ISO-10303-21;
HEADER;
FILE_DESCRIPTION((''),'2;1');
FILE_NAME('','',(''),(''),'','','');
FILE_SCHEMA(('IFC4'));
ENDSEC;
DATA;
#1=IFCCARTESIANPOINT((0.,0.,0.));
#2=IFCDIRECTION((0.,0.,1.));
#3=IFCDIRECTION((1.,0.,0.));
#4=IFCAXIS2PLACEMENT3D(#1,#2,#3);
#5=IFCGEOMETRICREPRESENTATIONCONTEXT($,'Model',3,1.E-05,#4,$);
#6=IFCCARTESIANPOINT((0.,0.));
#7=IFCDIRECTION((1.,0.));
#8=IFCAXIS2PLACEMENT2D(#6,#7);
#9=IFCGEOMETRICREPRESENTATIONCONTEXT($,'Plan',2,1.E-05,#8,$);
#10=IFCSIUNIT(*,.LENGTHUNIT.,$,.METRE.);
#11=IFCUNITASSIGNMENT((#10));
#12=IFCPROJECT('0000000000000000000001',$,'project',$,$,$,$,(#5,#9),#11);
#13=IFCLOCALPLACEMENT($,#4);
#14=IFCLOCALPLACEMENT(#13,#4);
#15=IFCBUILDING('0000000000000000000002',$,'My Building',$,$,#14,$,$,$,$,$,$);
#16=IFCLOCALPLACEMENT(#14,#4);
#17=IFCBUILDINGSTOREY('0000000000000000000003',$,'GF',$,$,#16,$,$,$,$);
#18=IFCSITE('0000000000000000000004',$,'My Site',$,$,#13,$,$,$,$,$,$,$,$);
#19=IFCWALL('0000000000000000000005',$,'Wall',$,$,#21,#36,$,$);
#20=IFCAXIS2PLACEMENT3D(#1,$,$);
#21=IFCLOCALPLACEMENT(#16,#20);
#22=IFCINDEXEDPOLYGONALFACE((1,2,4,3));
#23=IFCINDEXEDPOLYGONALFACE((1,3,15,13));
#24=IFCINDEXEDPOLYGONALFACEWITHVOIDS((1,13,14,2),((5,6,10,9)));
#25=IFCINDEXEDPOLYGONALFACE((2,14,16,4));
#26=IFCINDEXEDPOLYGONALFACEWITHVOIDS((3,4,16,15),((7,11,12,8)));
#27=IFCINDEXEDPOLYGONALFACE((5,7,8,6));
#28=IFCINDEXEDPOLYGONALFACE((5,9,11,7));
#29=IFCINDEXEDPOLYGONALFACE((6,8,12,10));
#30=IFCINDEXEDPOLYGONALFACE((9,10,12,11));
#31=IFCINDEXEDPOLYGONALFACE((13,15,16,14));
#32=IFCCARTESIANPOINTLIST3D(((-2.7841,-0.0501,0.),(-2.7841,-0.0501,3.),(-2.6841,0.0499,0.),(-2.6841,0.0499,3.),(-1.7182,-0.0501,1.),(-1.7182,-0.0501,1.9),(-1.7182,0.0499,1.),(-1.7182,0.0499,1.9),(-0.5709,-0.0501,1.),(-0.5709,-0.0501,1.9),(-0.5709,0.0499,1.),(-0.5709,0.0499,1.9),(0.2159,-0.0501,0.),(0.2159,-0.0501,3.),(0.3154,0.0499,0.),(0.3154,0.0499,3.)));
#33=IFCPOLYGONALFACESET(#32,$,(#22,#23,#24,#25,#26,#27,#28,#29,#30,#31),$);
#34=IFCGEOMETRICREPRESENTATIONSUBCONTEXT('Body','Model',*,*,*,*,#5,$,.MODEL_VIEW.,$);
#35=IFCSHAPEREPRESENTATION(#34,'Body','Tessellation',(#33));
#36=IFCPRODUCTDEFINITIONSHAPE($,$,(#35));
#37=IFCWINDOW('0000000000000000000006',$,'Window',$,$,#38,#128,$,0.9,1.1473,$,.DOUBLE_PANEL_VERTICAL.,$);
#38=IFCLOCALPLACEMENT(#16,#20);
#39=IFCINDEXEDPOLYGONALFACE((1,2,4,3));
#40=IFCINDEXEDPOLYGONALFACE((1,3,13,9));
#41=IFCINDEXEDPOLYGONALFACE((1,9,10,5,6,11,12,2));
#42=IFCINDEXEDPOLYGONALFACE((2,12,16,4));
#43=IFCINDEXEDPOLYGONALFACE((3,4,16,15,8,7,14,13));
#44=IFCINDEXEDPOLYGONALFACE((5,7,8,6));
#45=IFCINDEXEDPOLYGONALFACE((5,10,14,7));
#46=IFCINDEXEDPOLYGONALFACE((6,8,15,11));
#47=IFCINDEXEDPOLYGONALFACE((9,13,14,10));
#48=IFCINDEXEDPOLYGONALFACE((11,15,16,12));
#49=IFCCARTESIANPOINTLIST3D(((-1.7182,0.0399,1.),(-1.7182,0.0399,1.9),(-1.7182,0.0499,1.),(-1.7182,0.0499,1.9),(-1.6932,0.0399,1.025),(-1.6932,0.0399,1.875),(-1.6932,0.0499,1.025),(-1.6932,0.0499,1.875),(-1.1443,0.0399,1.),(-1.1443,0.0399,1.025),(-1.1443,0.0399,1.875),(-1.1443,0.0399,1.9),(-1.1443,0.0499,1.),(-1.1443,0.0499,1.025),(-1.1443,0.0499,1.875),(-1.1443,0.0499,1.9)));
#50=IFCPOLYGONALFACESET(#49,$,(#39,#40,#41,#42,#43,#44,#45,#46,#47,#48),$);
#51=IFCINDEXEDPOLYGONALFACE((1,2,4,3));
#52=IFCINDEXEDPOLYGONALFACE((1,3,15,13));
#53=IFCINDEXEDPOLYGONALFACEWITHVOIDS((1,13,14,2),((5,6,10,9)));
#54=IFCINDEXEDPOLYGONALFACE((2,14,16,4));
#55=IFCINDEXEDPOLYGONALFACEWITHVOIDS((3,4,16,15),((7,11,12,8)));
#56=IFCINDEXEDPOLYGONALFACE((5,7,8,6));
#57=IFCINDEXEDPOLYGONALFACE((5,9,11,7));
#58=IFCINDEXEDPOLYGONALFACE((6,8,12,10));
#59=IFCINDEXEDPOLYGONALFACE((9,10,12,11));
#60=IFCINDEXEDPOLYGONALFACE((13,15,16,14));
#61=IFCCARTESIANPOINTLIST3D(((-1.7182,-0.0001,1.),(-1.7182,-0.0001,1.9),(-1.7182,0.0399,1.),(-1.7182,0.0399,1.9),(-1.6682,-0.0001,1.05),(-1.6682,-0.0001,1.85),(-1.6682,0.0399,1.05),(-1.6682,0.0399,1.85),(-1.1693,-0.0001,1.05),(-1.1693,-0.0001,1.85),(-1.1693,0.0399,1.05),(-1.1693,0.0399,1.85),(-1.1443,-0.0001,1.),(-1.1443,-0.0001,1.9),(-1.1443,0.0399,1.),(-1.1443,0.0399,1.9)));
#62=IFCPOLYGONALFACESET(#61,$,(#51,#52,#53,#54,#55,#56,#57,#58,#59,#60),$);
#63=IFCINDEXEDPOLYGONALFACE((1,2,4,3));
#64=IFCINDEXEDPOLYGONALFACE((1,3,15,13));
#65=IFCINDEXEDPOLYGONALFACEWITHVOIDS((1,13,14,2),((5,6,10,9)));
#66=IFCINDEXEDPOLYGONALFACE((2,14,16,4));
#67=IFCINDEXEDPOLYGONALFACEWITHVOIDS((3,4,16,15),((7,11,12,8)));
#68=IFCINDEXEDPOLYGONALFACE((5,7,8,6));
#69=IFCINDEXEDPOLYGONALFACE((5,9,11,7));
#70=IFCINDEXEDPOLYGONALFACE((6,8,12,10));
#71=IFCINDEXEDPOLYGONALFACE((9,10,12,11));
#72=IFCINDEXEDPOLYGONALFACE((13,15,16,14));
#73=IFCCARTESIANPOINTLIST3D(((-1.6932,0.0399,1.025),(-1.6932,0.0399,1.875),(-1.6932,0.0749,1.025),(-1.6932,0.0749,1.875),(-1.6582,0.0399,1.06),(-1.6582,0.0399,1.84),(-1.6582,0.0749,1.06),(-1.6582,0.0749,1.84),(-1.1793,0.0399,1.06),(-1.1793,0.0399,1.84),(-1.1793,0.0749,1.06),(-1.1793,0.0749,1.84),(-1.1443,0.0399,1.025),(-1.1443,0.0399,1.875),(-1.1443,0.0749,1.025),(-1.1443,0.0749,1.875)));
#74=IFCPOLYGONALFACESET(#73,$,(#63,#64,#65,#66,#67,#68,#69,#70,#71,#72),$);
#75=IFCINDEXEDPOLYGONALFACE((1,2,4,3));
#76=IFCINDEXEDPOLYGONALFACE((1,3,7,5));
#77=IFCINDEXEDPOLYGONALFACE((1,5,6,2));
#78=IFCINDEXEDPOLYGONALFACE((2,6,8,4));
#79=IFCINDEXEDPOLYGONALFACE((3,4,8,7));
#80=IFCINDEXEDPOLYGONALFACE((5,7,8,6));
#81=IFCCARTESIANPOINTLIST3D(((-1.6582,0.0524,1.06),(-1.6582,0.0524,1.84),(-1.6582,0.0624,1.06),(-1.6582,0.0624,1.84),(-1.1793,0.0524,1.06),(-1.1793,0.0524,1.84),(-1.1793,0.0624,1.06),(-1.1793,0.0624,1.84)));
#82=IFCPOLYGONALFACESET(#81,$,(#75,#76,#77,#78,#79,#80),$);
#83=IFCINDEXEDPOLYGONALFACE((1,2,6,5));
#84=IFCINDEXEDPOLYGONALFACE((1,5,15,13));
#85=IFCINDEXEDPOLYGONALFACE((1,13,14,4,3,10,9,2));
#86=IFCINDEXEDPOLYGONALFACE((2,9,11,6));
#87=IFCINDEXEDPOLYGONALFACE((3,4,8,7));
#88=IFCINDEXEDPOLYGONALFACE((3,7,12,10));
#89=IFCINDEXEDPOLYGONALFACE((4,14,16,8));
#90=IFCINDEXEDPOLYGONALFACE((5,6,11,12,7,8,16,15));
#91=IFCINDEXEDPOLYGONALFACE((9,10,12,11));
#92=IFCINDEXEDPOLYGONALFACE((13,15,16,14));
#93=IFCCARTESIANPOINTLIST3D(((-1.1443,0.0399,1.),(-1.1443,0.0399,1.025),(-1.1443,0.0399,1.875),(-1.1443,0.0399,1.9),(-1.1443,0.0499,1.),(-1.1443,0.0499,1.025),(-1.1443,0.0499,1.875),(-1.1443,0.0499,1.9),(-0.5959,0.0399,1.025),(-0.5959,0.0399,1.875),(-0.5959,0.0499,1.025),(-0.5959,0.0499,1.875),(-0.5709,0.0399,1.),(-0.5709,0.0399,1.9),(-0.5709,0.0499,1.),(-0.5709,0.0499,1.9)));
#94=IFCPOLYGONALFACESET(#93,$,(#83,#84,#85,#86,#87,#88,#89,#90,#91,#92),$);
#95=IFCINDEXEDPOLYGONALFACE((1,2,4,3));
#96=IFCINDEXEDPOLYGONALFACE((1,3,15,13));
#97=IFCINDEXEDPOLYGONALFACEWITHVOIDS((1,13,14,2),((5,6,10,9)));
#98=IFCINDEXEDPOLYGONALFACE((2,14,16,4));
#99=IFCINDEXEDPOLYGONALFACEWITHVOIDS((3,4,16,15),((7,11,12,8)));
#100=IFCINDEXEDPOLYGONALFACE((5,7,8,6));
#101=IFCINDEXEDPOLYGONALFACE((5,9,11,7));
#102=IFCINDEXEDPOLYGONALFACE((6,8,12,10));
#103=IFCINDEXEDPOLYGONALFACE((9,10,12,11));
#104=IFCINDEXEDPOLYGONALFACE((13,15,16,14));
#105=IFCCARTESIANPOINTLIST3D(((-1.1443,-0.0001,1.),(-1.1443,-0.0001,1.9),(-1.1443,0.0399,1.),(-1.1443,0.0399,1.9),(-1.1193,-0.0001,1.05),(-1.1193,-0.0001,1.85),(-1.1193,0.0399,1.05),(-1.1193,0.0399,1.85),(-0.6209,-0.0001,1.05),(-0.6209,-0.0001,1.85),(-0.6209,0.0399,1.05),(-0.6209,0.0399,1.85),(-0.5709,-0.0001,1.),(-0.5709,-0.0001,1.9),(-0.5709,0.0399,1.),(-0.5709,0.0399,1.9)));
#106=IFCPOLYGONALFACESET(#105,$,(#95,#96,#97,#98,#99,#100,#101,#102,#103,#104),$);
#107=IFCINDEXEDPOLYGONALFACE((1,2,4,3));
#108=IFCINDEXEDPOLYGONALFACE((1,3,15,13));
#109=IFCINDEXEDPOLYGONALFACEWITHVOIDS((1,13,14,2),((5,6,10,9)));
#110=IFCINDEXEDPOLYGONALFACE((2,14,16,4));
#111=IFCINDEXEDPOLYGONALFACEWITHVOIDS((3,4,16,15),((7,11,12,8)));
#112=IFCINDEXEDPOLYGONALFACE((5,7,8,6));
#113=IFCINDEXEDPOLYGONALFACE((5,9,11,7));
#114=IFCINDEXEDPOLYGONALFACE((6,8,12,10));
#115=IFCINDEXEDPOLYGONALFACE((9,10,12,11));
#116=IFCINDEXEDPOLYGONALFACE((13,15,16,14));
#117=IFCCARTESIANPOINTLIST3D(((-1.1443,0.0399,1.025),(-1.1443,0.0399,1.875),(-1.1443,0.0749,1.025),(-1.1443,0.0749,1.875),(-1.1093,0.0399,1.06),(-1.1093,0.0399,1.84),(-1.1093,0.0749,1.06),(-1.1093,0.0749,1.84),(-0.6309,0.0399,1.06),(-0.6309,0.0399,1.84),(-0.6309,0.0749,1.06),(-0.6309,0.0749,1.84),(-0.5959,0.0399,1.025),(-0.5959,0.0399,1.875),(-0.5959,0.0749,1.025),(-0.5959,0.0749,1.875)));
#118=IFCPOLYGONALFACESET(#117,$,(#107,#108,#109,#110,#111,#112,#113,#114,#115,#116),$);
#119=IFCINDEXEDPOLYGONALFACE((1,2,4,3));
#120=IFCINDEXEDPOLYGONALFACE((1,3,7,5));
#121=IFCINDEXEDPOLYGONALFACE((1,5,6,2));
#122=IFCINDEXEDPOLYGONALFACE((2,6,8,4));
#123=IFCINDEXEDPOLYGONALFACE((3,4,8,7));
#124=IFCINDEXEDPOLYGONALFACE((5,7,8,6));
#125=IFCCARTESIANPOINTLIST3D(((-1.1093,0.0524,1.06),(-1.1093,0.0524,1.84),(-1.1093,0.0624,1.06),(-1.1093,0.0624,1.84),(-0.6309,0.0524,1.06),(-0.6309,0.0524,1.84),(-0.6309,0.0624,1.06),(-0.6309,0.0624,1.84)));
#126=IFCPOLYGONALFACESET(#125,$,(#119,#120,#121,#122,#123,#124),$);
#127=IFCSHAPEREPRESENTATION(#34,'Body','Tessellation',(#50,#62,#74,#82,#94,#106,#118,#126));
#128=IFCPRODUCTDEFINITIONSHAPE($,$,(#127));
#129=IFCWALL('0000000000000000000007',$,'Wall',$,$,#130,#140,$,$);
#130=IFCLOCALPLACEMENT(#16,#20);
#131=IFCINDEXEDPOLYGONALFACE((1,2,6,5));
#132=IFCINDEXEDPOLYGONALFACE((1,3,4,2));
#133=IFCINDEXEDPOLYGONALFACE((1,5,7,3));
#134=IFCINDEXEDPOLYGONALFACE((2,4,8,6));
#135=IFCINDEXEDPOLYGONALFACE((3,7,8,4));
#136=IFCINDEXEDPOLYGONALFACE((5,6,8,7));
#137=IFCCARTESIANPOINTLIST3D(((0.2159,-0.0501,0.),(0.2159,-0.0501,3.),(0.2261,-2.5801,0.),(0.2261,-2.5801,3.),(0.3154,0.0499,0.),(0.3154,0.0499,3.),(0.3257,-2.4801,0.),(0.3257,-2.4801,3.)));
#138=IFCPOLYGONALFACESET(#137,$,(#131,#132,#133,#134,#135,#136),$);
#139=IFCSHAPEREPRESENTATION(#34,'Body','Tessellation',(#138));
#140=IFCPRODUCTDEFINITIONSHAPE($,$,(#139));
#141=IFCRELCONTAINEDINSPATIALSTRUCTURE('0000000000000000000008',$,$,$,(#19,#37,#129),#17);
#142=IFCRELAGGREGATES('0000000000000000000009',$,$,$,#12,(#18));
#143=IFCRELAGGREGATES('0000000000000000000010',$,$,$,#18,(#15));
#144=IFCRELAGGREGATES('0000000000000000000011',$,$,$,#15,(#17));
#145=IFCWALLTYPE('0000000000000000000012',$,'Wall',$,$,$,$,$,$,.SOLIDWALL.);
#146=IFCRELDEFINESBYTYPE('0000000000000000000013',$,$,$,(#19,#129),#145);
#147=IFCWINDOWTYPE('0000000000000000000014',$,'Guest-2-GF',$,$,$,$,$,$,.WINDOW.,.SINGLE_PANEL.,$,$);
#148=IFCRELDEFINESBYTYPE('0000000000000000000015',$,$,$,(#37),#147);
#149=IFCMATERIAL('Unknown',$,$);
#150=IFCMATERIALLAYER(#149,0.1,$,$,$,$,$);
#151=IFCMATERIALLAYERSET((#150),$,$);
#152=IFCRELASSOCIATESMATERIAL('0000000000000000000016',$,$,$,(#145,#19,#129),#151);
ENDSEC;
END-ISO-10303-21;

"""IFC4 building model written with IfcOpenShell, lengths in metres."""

from ifc_helpers import new_model, entity, si_unit, frame, origin_with_axes, origin_2d_with_axis, place, context, subcontext, project, spatial, line, indexed_curve, outline, extrude, shape, source, transform, mapped, material, layer, layer_set, layer_usage, type_object, type_shapes, element, fill, save


model = new_model("IFC4")

# Units and contexts
model_context = context("Model", 3, precision=1e-05, world=origin_with_axes())
plan_context = context("Plan", 2, precision=1e-05, world=origin_2d_with_axis())
body_context_1 = subcontext(model_context, "Body", "Model", "MODEL_VIEW")
body_context_2 = subcontext(plan_context, "Body", "Plan", "PLAN_VIEW")
ifc_project = project(units=[si_unit("LENGTHUNIT", "METRE")], contexts=[model_context, plan_context])

# Site, building, storey
site_placement = place(None, origin_with_axes())
site = spatial("IfcSite", under=ifc_project, at=site_placement, Name="My Site")
building_placement = place(site_placement, origin_with_axes())
building = spatial("IfcBuilding", under=site, at=building_placement, Name="My Building")
storey_placement = place(building_placement, origin_with_axes())
storey = spatial("IfcBuildingStorey", under=building, at=storey_placement, Name="GF")

# Shared definitions
ifc_material_1 = material(Name="Unknown")

# Shared definitions
ifc_layer_1 = layer(ifc_material_1, 0.1)
ifc_layer_set_1 = layer_set([ifc_layer_1])
wall_type = type_object("IfcWallType", Name="Wall", PredefinedType="SOLIDWALL", material=ifc_layer_set_1)

# Wall, opening, window
ifc_layer_usage_1 = layer_usage(ifc_layer_set_1, "AXIS2", "POSITIVE", 0.0)
wall_1_placement = place(storey_placement, frame((-2.7841, -0.0501, 0.0), z_axis=(0.0, 0.0, 1.0), x_axis=(1.0, 0.0, 0.0)))
wall_1 = element("IfcWall", 1, at=wall_1_placement, inside=storey, type_object=wall_type, material=ifc_layer_usage_1, Name="Wall", context=body_context_1, shape_type="SweptSolid", body=[
    extrude(outline(indexed_curve([(0.0, 0.0), (0.1, 0.1), (3.0996, 0.1), (3.0, 0.0)], segments=[line(1, 2, 3, 4, 1)])), origin_with_axes(), (0.0, 0.0, 1.0), 3.0),
])
shared_shape_1 = source(origin_with_axes(), body_context_1, "Body", "SweptSolid", [
    extrude(outline(indexed_curve([(0.0, 0.0), (1.1473, 0.0), (1.1473, 0.9), (0.0, 0.9)], segments=[line(1, 2, 3, 4, 1)])), frame((0.0, -0.6, 0.0), z_axis=(0.0, -1.0, 0.0), x_axis=(1.0, 0.0, 0.0)), (0.0, 0.0, -1.0), 1.2),
])
opening_1_placement = place(wall_1_placement, frame((1.066, 0.0, 1.0), z_axis=(0.0, 0.0, 1.0), x_axis=(1.0, 0.0, 0.0)))
opening_1 = element("IfcOpeningElement", 2, at=opening_1_placement, cuts=wall_1, PredefinedType="OPENING", context=body_context_1, shape_type="MappedRepresentation", body=[
    mapped(shared_shape_1, transform((0.0, 0.0, 0.0), x_axis=(1.0, 0.0, 0.0), y_axis=(0.0, 1.0, 0.0), z_axis=(0.0, 0.0, 1.0), scale=1.0)),
])
window_type_1 = type_object("IfcWindowType", Name="Guest-2-GF", PartitioningType="SINGLE_PANEL", PredefinedType="WINDOW")
shared_shape_2 = source(origin_with_axes(), body_context_1, "Body", "SweptSolid", [
    extrude(outline(indexed_curve([(0.5739, 0.0), (0.0, 0.0), (0.0, 0.9), (0.5739, 0.9), (0.5739, 0.875), (0.025, 0.875), (0.025, 0.025), (0.5739, 0.025)], segments=[line(1, 2, 3, 4, 5, 6, 7, 8, 1)])), frame((0.0, 0.09, 0.0), z_axis=(0.0, -1.0, 0.0), x_axis=(1.0, 0.0, 0.0)), (0.0, 0.0, -1.0), 0.01),
    extrude(outline(indexed_curve([(0.0, 0.0), (0.5739, 0.0), (0.5739, 0.9), (0.0, 0.9)], segments=[line(1, 2, 3, 4, 1)]), holes=[indexed_curve([(0.05, 0.05), (0.5489, 0.05), (0.5489, 0.85), (0.05, 0.85)], segments=[line(1, 2, 3, 4, 1)])]), frame((0.0, 0.05, 0.0), z_axis=(0.0, -1.0, 0.0), x_axis=(1.0, 0.0, 0.0)), (0.0, 0.0, -1.0), 0.04),
    extrude(outline(indexed_curve([(0.0, 0.0), (0.5489, 0.0), (0.5489, 0.85), (0.0, 0.85)], segments=[line(1, 2, 3, 4, 1)]), holes=[indexed_curve([(0.035, 0.035), (0.5139, 0.035), (0.5139, 0.815), (0.035, 0.815)], segments=[line(1, 2, 3, 4, 1)])]), frame((0.025, 0.09, 0.025), z_axis=(0.0, -1.0, 0.0), x_axis=(1.0, 0.0, 0.0)), (0.0, 0.0, -1.0), 0.035),
    extrude(outline(indexed_curve([(0.035, 0.035), (0.5139, 0.035), (0.5139, 0.815), (0.035, 0.815)], segments=[line(1, 2, 3, 4, 1)])), frame((0.025, 0.1025, 0.025), z_axis=(0.0, -1.0, 0.0), x_axis=(1.0, 0.0, 0.0)), (0.0, 0.0, -1.0), 0.01),
    extrude(outline(indexed_curve([(0.0, 0.9), (0.5733, 0.9), (0.5733, 0.0), (0.0, 0.0), (0.0, 0.025), (0.5483, 0.025), (0.5483, 0.875), (0.0, 0.875)], segments=[line(1, 2, 3, 4, 5, 6, 7, 8, 1)])), frame((0.5739, 0.09, 0.0), z_axis=(0.0, -1.0, 0.0), x_axis=(1.0, 0.0, 0.0)), (0.0, 0.0, -1.0), 0.01),
    extrude(outline(indexed_curve([(0.0, 0.0), (0.5733, 0.0), (0.5733, 0.9), (0.0, 0.9)], segments=[line(1, 2, 3, 4, 1)]), holes=[indexed_curve([(0.025, 0.05), (0.5233, 0.05), (0.5233, 0.85), (0.025, 0.85)], segments=[line(1, 2, 3, 4, 1)])]), frame((0.5739, 0.05, 0.0), z_axis=(0.0, -1.0, 0.0), x_axis=(1.0, 0.0, 0.0)), (0.0, 0.0, -1.0), 0.04),
    extrude(outline(indexed_curve([(0.0, 0.0), (0.5483, 0.0), (0.5483, 0.85), (0.0, 0.85)], segments=[line(1, 2, 3, 4, 1)]), holes=[indexed_curve([(0.035, 0.035), (0.5133, 0.035), (0.5133, 0.815), (0.035, 0.815)], segments=[line(1, 2, 3, 4, 1)])]), frame((0.5739, 0.09, 0.025), z_axis=(0.0, -1.0, 0.0), x_axis=(1.0, 0.0, 0.0)), (0.0, 0.0, -1.0), 0.035),
    extrude(outline(indexed_curve([(0.035, 0.035), (0.5133, 0.035), (0.5133, 0.815), (0.035, 0.815)], segments=[line(1, 2, 3, 4, 1)])), frame((0.5739, 0.1025, 0.025), z_axis=(0.0, -1.0, 0.0), x_axis=(1.0, 0.0, 0.0)), (0.0, 0.0, -1.0), 0.01),
])
shared_shape_3 = source(origin_with_axes(), body_context_2, "Body", "Curve2D", [
    entity("IfcIndexedPolyCurve", entity("IfcCartesianPointList2D", [[0.05, 0.05], [0.5489, 0.05]])),
    entity("IfcIndexedPolyCurve", entity("IfcCartesianPointList2D", [[0.0, 0.1], [0.025, 0.1], [0.025, 0.09], [0.05, 0.09], [0.05, 0.05], [0.0, 0.05]]), [entity("IfcLineIndex", [1, 2, 3, 4, 5, 6, 1])]),
    entity("IfcIndexedPolyCurve", entity("IfcCartesianPointList2D", [[0.5739, 0.1], [0.5739, 0.1], [0.5739, 0.09], [0.5489, 0.09], [0.5489, 0.05], [0.5739, 0.05]])),
    entity("IfcIndexedPolyCurve", entity("IfcCartesianPointList2D", [[0.025, 0.09], [0.06, 0.09], [0.06, 0.125], [0.025, 0.125]]), [entity("IfcLineIndex", [1, 2, 3, 4, 1])]),
    entity("IfcIndexedPolyCurve", entity("IfcCartesianPointList2D", [[0.5739, 0.09], [0.5389, 0.09], [0.5389, 0.125], [0.5739, 0.125]]), [entity("IfcLineIndex", [1, 2, 3, 4, 1])]),
    entity("IfcIndexedPolyCurve", entity("IfcCartesianPointList2D", [[0.06, 0.09], [0.5389, 0.09]])),
    entity("IfcIndexedPolyCurve", entity("IfcCartesianPointList2D", [[0.06, 0.125], [0.5389, 0.125]])),
    entity("IfcIndexedPolyCurve", entity("IfcCartesianPointList2D", [[0.06, 0.1075], [0.5389, 0.1075]])),
    entity("IfcIndexedPolyCurve", entity("IfcCartesianPointList2D", [[0.5989, 0.05], [1.0973, 0.05]])),
    entity("IfcIndexedPolyCurve", entity("IfcCartesianPointList2D", [[0.5739, 0.1], [0.5739, 0.1], [0.5739, 0.09], [0.5989, 0.09], [0.5989, 0.05], [0.5739, 0.05]])),
    entity("IfcIndexedPolyCurve", entity("IfcCartesianPointList2D", [[1.1473, 0.1], [1.1223, 0.1], [1.1223, 0.09], [1.0973, 0.09], [1.0973, 0.05], [1.1473, 0.05]]), [entity("IfcLineIndex", [1, 2, 3, 4, 5, 6, 1])]),
    entity("IfcIndexedPolyCurve", entity("IfcCartesianPointList2D", [[0.5739, 0.09], [0.6089, 0.09], [0.6089, 0.125], [0.5739, 0.125]]), [entity("IfcLineIndex", [1, 2, 3, 4, 1])]),
    entity("IfcIndexedPolyCurve", entity("IfcCartesianPointList2D", [[1.1223, 0.09], [1.0873, 0.09], [1.0873, 0.125], [1.1223, 0.125]]), [entity("IfcLineIndex", [1, 2, 3, 4, 1])]),
    entity("IfcIndexedPolyCurve", entity("IfcCartesianPointList2D", [[0.6089, 0.09], [1.0873, 0.09]])),
    entity("IfcIndexedPolyCurve", entity("IfcCartesianPointList2D", [[0.6089, 0.125], [1.0873, 0.125]])),
    entity("IfcIndexedPolyCurve", entity("IfcCartesianPointList2D", [[0.6089, 0.1075], [1.0873, 0.1075]])),
])
type_shapes(window_type_1, [shared_shape_2, shared_shape_3])
window_1_placement = place(opening_1_placement, origin_with_axes())
window_1 = element("IfcWindow", 3, at=window_1_placement, inside=storey, type_object=window_type_1, Name="Window", OverallHeight=0.9, OverallWidth=1.1473, PartitioningType="DOUBLE_PANEL_VERTICAL", shapes=[
    shape(body_context_1, "Body", "MappedRepresentation", [mapped(shared_shape_2, transform((0.0, 0.0, 0.0), x_axis=(1.0, 0.0, 0.0), y_axis=(0.0, 1.0, 0.0), z_axis=(0.0, 0.0, 1.0), scale=1.0))]),
    shape(body_context_2, "Body", "MappedRepresentation", [mapped(shared_shape_3, transform((0.0, 0.0, 0.0), x_axis=(1.0, 0.0, 0.0), y_axis=(0.0, 1.0, 0.0), z_axis=(0.0, 0.0, 1.0), scale=1.0))]),
])
fill(opening_1, window_1)

# Wall
ifc_layer_usage_2 = layer_usage(ifc_layer_set_1, "AXIS2", "POSITIVE", 0.0)
wall_2_placement = place(storey_placement, frame((0.2159, -0.0501, 0.0), z_axis=(0.0, 0.0, 1.0), x_axis=(0.004067, -0.999992, 0.0)))
element("IfcWall", 4, at=wall_2_placement, inside=storey, type_object=wall_type, material=ifc_layer_usage_2, Name="Wall", context=body_context_1, shape_type="SweptSolid", body=[
    extrude(outline(indexed_curve([(0.0, 0.0), (-0.0996, 0.1), (2.4304, 0.1), (2.53, 0.0)], segments=[line(1, 2, 3, 4, 1)])), origin_with_axes(), (0.0, 0.0, 1.0), 3.0),
])

save(model, "model.ifc")
